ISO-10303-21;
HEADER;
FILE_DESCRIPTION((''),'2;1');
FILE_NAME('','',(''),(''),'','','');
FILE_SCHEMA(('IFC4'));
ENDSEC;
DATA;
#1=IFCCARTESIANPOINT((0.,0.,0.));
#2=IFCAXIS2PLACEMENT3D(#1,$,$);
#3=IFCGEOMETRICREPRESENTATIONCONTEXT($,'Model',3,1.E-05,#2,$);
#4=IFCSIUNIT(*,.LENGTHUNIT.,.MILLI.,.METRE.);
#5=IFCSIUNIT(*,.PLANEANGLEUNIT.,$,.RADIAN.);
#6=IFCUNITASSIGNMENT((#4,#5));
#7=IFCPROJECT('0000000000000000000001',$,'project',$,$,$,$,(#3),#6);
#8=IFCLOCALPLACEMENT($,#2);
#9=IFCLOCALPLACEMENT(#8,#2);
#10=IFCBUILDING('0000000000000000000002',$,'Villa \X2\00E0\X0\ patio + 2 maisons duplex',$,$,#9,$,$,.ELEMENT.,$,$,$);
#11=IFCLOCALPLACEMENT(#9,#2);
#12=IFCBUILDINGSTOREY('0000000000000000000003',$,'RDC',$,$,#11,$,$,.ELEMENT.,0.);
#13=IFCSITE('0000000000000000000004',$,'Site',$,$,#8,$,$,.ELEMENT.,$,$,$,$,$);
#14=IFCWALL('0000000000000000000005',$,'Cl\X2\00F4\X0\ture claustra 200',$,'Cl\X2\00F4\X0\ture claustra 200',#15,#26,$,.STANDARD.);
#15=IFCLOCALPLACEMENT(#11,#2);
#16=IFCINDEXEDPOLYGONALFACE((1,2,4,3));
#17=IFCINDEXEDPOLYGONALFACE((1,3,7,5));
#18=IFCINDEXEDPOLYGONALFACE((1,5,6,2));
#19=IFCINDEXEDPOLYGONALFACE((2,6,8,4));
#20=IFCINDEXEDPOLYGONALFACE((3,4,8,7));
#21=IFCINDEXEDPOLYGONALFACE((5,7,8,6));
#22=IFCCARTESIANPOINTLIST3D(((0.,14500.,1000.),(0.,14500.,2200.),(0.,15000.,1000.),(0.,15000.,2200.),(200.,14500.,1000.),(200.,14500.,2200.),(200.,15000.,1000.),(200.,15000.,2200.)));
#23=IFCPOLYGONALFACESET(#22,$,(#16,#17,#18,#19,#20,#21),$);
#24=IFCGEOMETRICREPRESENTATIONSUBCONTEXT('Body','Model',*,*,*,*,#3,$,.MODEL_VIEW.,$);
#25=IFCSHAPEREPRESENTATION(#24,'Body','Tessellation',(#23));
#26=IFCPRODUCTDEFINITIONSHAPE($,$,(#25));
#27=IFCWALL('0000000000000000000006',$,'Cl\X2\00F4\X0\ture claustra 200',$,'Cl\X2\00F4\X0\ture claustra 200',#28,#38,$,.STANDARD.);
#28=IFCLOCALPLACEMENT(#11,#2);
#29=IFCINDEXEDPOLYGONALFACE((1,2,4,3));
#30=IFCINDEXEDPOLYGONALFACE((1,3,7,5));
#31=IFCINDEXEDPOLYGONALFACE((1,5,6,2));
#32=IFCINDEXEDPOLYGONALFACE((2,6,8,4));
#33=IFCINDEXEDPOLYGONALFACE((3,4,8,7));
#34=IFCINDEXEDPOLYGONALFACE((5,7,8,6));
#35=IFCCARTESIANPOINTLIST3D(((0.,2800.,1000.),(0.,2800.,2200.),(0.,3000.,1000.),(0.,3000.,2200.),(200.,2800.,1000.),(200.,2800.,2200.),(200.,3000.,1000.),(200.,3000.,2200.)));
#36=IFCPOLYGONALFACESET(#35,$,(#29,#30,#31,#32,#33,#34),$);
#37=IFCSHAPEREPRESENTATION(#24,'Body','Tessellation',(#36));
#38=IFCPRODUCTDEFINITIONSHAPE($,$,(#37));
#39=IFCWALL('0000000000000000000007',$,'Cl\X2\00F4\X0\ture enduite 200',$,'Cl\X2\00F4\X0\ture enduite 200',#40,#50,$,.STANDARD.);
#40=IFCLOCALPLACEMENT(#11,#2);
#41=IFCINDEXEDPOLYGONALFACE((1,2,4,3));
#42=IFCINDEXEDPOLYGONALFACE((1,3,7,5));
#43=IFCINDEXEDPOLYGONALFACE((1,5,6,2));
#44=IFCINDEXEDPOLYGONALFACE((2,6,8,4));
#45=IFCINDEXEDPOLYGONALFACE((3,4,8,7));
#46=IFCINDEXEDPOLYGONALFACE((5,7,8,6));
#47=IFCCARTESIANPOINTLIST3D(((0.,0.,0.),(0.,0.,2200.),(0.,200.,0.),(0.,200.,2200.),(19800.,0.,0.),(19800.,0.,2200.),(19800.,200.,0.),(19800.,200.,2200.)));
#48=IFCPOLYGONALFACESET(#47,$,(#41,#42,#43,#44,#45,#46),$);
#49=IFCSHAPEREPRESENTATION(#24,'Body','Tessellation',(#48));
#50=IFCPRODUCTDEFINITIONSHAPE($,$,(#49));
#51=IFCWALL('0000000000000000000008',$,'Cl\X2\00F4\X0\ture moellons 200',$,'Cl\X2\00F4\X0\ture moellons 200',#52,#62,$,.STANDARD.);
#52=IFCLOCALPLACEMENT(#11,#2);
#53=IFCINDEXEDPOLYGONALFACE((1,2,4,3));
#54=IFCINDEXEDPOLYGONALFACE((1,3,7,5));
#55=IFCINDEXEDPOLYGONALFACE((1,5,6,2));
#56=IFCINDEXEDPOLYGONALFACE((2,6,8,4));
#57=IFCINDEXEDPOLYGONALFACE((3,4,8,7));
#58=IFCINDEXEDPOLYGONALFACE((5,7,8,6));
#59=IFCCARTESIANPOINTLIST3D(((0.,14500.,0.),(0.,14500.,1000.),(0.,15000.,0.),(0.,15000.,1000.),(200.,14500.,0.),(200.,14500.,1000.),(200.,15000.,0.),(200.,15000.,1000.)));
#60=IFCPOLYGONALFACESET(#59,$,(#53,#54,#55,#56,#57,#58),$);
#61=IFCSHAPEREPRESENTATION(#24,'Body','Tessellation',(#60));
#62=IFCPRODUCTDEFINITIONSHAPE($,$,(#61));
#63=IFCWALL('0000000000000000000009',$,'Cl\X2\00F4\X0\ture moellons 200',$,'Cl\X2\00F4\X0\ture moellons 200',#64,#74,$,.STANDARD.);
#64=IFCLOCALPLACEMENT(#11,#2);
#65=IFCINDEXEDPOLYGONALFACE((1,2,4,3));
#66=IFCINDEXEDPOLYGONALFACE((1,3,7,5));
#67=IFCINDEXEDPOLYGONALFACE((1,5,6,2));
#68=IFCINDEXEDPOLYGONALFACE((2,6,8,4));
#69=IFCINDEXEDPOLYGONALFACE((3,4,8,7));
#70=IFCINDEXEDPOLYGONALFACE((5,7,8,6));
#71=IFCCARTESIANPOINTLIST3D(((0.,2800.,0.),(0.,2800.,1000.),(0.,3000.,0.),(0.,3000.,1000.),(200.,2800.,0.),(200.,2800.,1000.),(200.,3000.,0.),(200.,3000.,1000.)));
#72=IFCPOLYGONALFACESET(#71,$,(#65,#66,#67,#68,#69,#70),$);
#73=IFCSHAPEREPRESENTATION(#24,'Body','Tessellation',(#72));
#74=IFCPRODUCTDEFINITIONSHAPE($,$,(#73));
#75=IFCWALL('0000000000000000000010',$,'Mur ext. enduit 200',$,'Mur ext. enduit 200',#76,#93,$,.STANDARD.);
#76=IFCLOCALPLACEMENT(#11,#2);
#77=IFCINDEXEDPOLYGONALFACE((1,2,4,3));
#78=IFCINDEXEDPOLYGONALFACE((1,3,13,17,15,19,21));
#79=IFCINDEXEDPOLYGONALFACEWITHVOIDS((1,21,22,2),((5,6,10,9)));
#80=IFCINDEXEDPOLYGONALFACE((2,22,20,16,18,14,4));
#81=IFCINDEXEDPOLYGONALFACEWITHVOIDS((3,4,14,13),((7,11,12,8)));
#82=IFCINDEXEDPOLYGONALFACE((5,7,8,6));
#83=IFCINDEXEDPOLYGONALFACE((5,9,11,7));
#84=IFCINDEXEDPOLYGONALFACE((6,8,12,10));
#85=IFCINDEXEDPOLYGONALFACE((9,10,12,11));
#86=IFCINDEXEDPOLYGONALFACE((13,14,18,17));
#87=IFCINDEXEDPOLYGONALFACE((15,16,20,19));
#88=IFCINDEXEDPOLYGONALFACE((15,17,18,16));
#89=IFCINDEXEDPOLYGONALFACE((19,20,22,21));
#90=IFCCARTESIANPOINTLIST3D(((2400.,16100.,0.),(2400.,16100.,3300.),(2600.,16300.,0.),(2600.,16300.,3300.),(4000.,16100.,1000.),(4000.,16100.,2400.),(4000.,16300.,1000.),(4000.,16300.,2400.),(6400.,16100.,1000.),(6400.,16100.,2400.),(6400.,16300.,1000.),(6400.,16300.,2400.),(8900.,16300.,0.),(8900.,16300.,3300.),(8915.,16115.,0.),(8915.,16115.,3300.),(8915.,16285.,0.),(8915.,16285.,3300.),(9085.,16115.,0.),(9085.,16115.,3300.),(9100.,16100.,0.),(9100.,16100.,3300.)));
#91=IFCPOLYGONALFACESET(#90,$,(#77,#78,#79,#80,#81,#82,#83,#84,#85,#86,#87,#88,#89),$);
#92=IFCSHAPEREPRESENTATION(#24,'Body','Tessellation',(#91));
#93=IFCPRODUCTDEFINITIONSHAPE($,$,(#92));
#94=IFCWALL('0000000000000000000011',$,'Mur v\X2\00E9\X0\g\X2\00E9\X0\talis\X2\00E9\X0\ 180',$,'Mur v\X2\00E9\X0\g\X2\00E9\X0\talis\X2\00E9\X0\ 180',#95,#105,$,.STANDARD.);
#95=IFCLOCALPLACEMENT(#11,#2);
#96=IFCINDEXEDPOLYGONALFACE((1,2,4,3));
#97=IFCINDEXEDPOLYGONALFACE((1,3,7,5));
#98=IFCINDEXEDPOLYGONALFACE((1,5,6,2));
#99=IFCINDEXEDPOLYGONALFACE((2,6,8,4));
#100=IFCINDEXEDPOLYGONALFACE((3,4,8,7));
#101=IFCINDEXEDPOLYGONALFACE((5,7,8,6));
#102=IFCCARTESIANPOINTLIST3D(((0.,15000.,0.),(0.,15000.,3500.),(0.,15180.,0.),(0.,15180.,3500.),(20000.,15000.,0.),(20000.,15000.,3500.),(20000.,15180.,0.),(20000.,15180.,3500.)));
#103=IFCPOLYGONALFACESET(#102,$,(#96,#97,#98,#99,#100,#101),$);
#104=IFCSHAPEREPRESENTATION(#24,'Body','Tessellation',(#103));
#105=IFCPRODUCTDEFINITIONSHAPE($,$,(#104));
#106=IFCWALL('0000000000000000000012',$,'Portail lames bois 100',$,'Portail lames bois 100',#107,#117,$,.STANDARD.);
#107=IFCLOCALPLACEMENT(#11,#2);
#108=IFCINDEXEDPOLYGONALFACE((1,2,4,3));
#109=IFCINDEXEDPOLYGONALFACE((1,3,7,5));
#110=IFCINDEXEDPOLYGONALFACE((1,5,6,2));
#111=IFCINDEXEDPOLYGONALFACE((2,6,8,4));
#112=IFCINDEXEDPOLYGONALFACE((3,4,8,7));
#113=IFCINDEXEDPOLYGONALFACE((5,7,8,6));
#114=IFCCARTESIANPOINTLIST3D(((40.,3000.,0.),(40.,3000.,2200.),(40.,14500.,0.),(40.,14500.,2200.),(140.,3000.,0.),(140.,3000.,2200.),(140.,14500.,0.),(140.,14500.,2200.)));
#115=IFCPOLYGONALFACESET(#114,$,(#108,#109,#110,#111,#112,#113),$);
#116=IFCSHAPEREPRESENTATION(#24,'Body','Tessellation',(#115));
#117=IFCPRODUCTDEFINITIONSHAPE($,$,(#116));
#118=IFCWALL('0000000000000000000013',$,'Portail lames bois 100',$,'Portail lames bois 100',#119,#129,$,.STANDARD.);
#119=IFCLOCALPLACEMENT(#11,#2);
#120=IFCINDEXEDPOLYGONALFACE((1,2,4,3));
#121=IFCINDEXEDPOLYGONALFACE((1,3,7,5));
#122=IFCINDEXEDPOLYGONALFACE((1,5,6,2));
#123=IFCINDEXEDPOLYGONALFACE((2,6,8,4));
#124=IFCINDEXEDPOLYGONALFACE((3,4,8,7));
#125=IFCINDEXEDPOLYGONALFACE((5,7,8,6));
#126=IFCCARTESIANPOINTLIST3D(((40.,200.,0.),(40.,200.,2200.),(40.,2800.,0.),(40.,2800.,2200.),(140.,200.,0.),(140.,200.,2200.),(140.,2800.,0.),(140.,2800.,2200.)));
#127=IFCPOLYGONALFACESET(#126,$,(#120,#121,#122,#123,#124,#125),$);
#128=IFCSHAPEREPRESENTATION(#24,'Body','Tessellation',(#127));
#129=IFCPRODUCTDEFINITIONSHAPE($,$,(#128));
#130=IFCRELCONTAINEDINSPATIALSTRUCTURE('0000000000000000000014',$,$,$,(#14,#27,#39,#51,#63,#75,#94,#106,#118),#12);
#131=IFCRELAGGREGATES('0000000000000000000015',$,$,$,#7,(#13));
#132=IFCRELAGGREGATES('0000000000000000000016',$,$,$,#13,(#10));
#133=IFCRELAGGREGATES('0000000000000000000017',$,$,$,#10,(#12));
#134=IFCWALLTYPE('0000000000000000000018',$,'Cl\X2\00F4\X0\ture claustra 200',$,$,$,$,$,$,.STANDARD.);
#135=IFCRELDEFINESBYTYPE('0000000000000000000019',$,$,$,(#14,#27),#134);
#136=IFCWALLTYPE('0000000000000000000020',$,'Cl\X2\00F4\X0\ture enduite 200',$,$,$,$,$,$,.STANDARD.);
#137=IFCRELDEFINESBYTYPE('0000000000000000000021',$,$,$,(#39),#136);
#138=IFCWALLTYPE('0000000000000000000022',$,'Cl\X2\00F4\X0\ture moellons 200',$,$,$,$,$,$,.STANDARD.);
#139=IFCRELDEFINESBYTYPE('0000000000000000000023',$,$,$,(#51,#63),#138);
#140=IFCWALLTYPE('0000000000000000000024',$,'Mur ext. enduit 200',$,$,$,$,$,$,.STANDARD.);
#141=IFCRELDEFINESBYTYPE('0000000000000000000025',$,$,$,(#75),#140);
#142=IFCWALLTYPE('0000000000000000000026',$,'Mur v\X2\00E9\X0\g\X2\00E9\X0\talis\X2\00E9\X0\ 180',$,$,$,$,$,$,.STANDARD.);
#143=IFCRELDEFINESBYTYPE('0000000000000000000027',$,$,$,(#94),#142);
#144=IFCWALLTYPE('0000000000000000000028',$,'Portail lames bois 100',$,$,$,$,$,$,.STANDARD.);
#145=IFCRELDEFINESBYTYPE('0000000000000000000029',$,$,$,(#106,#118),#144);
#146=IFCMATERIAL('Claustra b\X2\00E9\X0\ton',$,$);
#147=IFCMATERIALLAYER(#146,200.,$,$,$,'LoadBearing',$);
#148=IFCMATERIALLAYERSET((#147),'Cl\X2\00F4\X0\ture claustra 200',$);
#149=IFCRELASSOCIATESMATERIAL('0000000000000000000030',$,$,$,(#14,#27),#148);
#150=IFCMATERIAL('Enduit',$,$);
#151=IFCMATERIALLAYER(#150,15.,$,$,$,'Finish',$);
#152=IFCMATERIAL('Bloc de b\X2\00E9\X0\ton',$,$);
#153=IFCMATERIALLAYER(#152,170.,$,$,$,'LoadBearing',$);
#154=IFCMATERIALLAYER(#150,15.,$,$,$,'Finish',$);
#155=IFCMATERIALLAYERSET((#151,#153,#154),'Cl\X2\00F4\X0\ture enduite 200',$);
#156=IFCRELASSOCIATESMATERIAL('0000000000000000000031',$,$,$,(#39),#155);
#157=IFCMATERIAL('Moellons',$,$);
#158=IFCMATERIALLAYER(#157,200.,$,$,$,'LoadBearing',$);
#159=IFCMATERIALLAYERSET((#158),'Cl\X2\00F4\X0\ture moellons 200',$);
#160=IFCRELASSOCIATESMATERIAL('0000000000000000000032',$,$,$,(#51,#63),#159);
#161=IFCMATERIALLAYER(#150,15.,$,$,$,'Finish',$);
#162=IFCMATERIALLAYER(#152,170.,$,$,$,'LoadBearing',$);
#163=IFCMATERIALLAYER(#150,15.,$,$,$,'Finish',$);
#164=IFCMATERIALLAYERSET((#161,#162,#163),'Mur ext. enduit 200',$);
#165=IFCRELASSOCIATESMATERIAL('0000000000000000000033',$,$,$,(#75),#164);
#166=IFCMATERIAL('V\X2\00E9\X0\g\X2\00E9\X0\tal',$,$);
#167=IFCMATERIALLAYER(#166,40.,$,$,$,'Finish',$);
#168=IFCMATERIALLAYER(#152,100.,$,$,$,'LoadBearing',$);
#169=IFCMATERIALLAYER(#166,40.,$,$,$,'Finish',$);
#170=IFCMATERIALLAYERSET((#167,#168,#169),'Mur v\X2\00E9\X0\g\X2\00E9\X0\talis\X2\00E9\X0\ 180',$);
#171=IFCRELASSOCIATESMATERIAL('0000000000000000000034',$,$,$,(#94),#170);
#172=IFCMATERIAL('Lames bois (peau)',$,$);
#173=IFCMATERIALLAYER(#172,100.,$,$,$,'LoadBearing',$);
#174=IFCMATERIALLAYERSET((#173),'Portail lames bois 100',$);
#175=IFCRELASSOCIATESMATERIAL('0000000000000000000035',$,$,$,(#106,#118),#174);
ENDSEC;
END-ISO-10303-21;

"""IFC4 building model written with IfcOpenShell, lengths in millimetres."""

from ifc_helpers import new_model, si_unit, frame, frame_2d, origin, place, context, subcontext, project, spatial, polyline, rectangle, outline, extrude, material, layer, layer_set, layer_usage, type_object, element, save


model = new_model("IFC4")

# Units and contexts
model_context = context("Model", 3, precision=1e-05, world=origin())
body_context = subcontext(model_context, "Body", "Model", "MODEL_VIEW")
ifc_project = project(units=[si_unit("LENGTHUNIT", "METRE", prefix="MILLI"), si_unit("PLANEANGLEUNIT", "RADIAN")], contexts=[model_context])

# Site, building, storey
site_placement = place(None, origin())
site = spatial("IfcSite", under=ifc_project, at=site_placement, Name="Site", CompositionType="ELEMENT")
building_placement = place(site_placement, origin())
building = spatial("IfcBuilding", under=site, at=building_placement, Name="Villa à patio + 2 maisons duplex", CompositionType="ELEMENT")
storey_placement = place(building_placement, origin())
storey = spatial("IfcBuildingStorey", under=building, at=storey_placement, Name="RDC", CompositionType="ELEMENT", Elevation=0.0)

# Walls
ifc_material_1 = material(Name="Claustra béton")
ifc_layer_1 = layer(ifc_material_1, 200.0, Category="LoadBearing")
ifc_layer_set_1 = layer_set([ifc_layer_1], Name="Clôture claustra 200")
ifc_layer_usage_1 = layer_usage(ifc_layer_set_1, "AXIS2", "NEGATIVE", 100.0)
wall_type_1 = type_object("IfcWallType", Name="Clôture claustra 200", PredefinedType="STANDARD")
wall_1_placement = place(storey_placement, frame((100.0, 15000.0, 1000.0), z_axis=(0.0, 0.0, 1.0), x_axis=(0.0, -1.0, 0.0)))
element("IfcWall", 1, at=wall_1_placement, inside=storey, type_object=wall_type_1, material=ifc_layer_usage_1, Name="Clôture claustra 200", ObjectType="Clôture claustra 200", PredefinedType="STANDARD", context=body_context, shape_type="SweptSolid", body=[
    extrude(outline(polyline([(0.0, -100.0), (0.0, 100.0), (500.0, 100.0), (500.0, -100.0), (0.0, -100.0)])), origin(), (0.0, 0.0, 1.0), 1200.0),
])
wall_2_placement = place(storey_placement, frame((100.0, 3000.0, 1000.0), z_axis=(0.0, 0.0, 1.0), x_axis=(0.0, -1.0, 0.0)))
element("IfcWall", 2, at=wall_2_placement, inside=storey, type_object=wall_type_1, material=ifc_layer_usage_1, Name="Clôture claustra 200", ObjectType="Clôture claustra 200", PredefinedType="STANDARD", context=body_context, shape_type="SweptSolid", body=[
    extrude(outline(polyline([(0.0, -100.0), (0.0, 100.0), (200.0, 100.0), (200.0, -100.0), (0.0, -100.0)])), origin(), (0.0, 0.0, 1.0), 1200.0),
])
ifc_material_2 = material(Name="Enduit")
ifc_layer_2 = layer(ifc_material_2, 15.0, Category="Finish")
ifc_material_3 = material(Name="Bloc de béton")
ifc_layer_3 = layer(ifc_material_3, 170.0, Category="LoadBearing")
ifc_layer_4 = layer(ifc_material_2, 15.0, Category="Finish")
ifc_layer_set_2 = layer_set([ifc_layer_2, ifc_layer_3, ifc_layer_4], Name="Clôture enduite 200")
ifc_layer_usage_2 = layer_usage(ifc_layer_set_2, "AXIS2", "NEGATIVE", 100.0)
wall_type_2 = type_object("IfcWallType", Name="Clôture enduite 200", PredefinedType="STANDARD")
wall_3_placement = place(storey_placement, frame((0.0, 100.0, 0.0), z_axis=(0.0, 0.0, 1.0), x_axis=(1.0, 0.0, 0.0)))
element("IfcWall", 3, at=wall_3_placement, inside=storey, type_object=wall_type_2, material=ifc_layer_usage_2, Name="Clôture enduite 200", ObjectType="Clôture enduite 200", PredefinedType="STANDARD", context=body_context, shape_type="SweptSolid", body=[
    extrude(outline(polyline([(0.0, -100.0), (0.0, 100.0), (19800.0, 100.0), (19800.0, -100.0), (0.0, -100.0)])), origin(), (0.0, 0.0, 1.0), 2200.0),
])
ifc_material_4 = material(Name="Moellons")
ifc_layer_5 = layer(ifc_material_4, 200.0, Category="LoadBearing")
ifc_layer_set_3 = layer_set([ifc_layer_5], Name="Clôture moellons 200")
ifc_layer_usage_3 = layer_usage(ifc_layer_set_3, "AXIS2", "NEGATIVE", 100.0)
wall_type_3 = type_object("IfcWallType", Name="Clôture moellons 200", PredefinedType="STANDARD")
wall_4_placement = place(storey_placement, frame((100.0, 15000.0, 0.0), z_axis=(0.0, 0.0, 1.0), x_axis=(0.0, -1.0, 0.0)))
element("IfcWall", 4, at=wall_4_placement, inside=storey, type_object=wall_type_3, material=ifc_layer_usage_3, Name="Clôture moellons 200", ObjectType="Clôture moellons 200", PredefinedType="STANDARD", context=body_context, shape_type="SweptSolid", body=[
    extrude(outline(polyline([(0.0, -100.0), (0.0, 100.0), (500.0, 100.0), (500.0, -100.0), (0.0, -100.0)])), origin(), (0.0, 0.0, 1.0), 1000.0),
])
wall_5_placement = place(storey_placement, frame((100.0, 3000.0, 0.0), z_axis=(0.0, 0.0, 1.0), x_axis=(0.0, -1.0, 0.0)))
element("IfcWall", 5, at=wall_5_placement, inside=storey, type_object=wall_type_3, material=ifc_layer_usage_3, Name="Clôture moellons 200", ObjectType="Clôture moellons 200", PredefinedType="STANDARD", context=body_context, shape_type="SweptSolid", body=[
    extrude(outline(polyline([(0.0, -100.0), (0.0, 100.0), (200.0, 100.0), (200.0, -100.0), (0.0, -100.0)])), origin(), (0.0, 0.0, 1.0), 1000.0),
])

# Wall, opening
ifc_layer_6 = layer(ifc_material_2, 15.0, Category="Finish")
ifc_layer_7 = layer(ifc_material_3, 170.0, Category="LoadBearing")
ifc_layer_8 = layer(ifc_material_2, 15.0, Category="Finish")
ifc_layer_set_4 = layer_set([ifc_layer_6, ifc_layer_7, ifc_layer_8], Name="Mur ext. enduit 200")
ifc_layer_usage_4 = layer_usage(ifc_layer_set_4, "AXIS2", "NEGATIVE", 100.0)
wall_type_4 = type_object("IfcWallType", Name="Mur ext. enduit 200", PredefinedType="STANDARD")
wall_6_placement = place(storey_placement, frame((2500.0, 16200.0, 0.0), z_axis=(0.0, 0.0, 1.0), x_axis=(1.0, 0.0, 0.0)))
wall_6 = element("IfcWall", 6, at=wall_6_placement, inside=storey, type_object=wall_type_4, material=ifc_layer_usage_4, Name="Mur ext. enduit 200", ObjectType="Mur ext. enduit 200", PredefinedType="STANDARD", context=body_context, shape_type="SweptSolid", body=[
    extrude(outline(polyline([(-100.0, -100.0), (0.0, 0.0), (100.0, 100.0), (6400.0, 100.0), (6415.0, 85.0), (6415.0, -85.0), (6585.0, -85.0), (6600.0, -100.0), (-100.0, -100.0)])), origin(), (0.0, 0.0, 1.0), 3300.0),
])
opening_placement = place(wall_6_placement, frame((1500.0, 0.0, 1000.0), z_axis=(0.0, 0.0, 1.0), x_axis=(1.0, 0.0, 0.0)))
element("IfcOpeningElement", 7, at=opening_placement, cuts=wall_6, PredefinedType="OPENING", context=body_context, shape_type="SweptSolid", body=[
    extrude(rectangle(XDim=2400.0, YDim=220.0, at=frame_2d((1200.0, 0.0))), origin(), (0.0, 0.0, 1.0), 1400.0),
])

# Walls
ifc_material_5 = material(Name="Végétal")
ifc_layer_9 = layer(ifc_material_5, 40.0, Category="Finish")
ifc_layer_10 = layer(ifc_material_3, 100.0, Category="LoadBearing")
ifc_layer_11 = layer(ifc_material_5, 40.0, Category="Finish")
ifc_layer_set_5 = layer_set([ifc_layer_9, ifc_layer_10, ifc_layer_11], Name="Mur végétalisé 180")
ifc_layer_usage_5 = layer_usage(ifc_layer_set_5, "AXIS2", "NEGATIVE", 90.0)
wall_type_5 = type_object("IfcWallType", Name="Mur végétalisé 180", PredefinedType="STANDARD")
wall_7_placement = place(storey_placement, frame((0.0, 15090.0, 0.0), z_axis=(0.0, 0.0, 1.0), x_axis=(1.0, 0.0, 0.0)))
element("IfcWall", 8, at=wall_7_placement, inside=storey, type_object=wall_type_5, material=ifc_layer_usage_5, Name="Mur végétalisé 180", ObjectType="Mur végétalisé 180", PredefinedType="STANDARD", context=body_context, shape_type="SweptSolid", body=[
    extrude(outline(polyline([(0.0, -90.0), (0.0, 90.0), (20000.0, 90.0), (20000.0, -90.0), (0.0, -90.0)])), origin(), (0.0, 0.0, 1.0), 3500.0),
])
ifc_material_6 = material(Name="Lames bois (peau)")
ifc_layer_12 = layer(ifc_material_6, 100.0, Category="LoadBearing")
ifc_layer_set_6 = layer_set([ifc_layer_12], Name="Portail lames bois 100")
ifc_layer_usage_6 = layer_usage(ifc_layer_set_6, "AXIS2", "NEGATIVE", 50.0)
wall_type_6 = type_object("IfcWallType", Name="Portail lames bois 100", PredefinedType="STANDARD")
wall_8_placement = place(storey_placement, frame((90.0, 14500.0, 0.0), z_axis=(0.0, 0.0, 1.0), x_axis=(0.0, -1.0, 0.0)))
element("IfcWall", 9, at=wall_8_placement, inside=storey, type_object=wall_type_6, material=ifc_layer_usage_6, Name="Portail lames bois 100", ObjectType="Portail lames bois 100", PredefinedType="STANDARD", context=body_context, shape_type="SweptSolid", body=[
    extrude(outline(polyline([(0.0, -50.0), (0.0, 50.0), (11500.0, 50.0), (11500.0, -50.0), (0.0, -50.0)])), origin(), (0.0, 0.0, 1.0), 2200.0),
])
wall_9_placement = place(storey_placement, frame((90.0, 2800.0, 0.0), z_axis=(0.0, 0.0, 1.0), x_axis=(0.0, -1.0, 0.0)))
element("IfcWall", 10, at=wall_9_placement, inside=storey, type_object=wall_type_6, material=ifc_layer_usage_6, Name="Portail lames bois 100", ObjectType="Portail lames bois 100", PredefinedType="STANDARD", context=body_context, shape_type="SweptSolid", body=[
    extrude(outline(polyline([(0.0, -50.0), (0.0, 50.0), (2600.0, 50.0), (2600.0, -50.0), (0.0, -50.0)])), origin(), (0.0, 0.0, 1.0), 2200.0),
])

save(model, "model.ifc")
